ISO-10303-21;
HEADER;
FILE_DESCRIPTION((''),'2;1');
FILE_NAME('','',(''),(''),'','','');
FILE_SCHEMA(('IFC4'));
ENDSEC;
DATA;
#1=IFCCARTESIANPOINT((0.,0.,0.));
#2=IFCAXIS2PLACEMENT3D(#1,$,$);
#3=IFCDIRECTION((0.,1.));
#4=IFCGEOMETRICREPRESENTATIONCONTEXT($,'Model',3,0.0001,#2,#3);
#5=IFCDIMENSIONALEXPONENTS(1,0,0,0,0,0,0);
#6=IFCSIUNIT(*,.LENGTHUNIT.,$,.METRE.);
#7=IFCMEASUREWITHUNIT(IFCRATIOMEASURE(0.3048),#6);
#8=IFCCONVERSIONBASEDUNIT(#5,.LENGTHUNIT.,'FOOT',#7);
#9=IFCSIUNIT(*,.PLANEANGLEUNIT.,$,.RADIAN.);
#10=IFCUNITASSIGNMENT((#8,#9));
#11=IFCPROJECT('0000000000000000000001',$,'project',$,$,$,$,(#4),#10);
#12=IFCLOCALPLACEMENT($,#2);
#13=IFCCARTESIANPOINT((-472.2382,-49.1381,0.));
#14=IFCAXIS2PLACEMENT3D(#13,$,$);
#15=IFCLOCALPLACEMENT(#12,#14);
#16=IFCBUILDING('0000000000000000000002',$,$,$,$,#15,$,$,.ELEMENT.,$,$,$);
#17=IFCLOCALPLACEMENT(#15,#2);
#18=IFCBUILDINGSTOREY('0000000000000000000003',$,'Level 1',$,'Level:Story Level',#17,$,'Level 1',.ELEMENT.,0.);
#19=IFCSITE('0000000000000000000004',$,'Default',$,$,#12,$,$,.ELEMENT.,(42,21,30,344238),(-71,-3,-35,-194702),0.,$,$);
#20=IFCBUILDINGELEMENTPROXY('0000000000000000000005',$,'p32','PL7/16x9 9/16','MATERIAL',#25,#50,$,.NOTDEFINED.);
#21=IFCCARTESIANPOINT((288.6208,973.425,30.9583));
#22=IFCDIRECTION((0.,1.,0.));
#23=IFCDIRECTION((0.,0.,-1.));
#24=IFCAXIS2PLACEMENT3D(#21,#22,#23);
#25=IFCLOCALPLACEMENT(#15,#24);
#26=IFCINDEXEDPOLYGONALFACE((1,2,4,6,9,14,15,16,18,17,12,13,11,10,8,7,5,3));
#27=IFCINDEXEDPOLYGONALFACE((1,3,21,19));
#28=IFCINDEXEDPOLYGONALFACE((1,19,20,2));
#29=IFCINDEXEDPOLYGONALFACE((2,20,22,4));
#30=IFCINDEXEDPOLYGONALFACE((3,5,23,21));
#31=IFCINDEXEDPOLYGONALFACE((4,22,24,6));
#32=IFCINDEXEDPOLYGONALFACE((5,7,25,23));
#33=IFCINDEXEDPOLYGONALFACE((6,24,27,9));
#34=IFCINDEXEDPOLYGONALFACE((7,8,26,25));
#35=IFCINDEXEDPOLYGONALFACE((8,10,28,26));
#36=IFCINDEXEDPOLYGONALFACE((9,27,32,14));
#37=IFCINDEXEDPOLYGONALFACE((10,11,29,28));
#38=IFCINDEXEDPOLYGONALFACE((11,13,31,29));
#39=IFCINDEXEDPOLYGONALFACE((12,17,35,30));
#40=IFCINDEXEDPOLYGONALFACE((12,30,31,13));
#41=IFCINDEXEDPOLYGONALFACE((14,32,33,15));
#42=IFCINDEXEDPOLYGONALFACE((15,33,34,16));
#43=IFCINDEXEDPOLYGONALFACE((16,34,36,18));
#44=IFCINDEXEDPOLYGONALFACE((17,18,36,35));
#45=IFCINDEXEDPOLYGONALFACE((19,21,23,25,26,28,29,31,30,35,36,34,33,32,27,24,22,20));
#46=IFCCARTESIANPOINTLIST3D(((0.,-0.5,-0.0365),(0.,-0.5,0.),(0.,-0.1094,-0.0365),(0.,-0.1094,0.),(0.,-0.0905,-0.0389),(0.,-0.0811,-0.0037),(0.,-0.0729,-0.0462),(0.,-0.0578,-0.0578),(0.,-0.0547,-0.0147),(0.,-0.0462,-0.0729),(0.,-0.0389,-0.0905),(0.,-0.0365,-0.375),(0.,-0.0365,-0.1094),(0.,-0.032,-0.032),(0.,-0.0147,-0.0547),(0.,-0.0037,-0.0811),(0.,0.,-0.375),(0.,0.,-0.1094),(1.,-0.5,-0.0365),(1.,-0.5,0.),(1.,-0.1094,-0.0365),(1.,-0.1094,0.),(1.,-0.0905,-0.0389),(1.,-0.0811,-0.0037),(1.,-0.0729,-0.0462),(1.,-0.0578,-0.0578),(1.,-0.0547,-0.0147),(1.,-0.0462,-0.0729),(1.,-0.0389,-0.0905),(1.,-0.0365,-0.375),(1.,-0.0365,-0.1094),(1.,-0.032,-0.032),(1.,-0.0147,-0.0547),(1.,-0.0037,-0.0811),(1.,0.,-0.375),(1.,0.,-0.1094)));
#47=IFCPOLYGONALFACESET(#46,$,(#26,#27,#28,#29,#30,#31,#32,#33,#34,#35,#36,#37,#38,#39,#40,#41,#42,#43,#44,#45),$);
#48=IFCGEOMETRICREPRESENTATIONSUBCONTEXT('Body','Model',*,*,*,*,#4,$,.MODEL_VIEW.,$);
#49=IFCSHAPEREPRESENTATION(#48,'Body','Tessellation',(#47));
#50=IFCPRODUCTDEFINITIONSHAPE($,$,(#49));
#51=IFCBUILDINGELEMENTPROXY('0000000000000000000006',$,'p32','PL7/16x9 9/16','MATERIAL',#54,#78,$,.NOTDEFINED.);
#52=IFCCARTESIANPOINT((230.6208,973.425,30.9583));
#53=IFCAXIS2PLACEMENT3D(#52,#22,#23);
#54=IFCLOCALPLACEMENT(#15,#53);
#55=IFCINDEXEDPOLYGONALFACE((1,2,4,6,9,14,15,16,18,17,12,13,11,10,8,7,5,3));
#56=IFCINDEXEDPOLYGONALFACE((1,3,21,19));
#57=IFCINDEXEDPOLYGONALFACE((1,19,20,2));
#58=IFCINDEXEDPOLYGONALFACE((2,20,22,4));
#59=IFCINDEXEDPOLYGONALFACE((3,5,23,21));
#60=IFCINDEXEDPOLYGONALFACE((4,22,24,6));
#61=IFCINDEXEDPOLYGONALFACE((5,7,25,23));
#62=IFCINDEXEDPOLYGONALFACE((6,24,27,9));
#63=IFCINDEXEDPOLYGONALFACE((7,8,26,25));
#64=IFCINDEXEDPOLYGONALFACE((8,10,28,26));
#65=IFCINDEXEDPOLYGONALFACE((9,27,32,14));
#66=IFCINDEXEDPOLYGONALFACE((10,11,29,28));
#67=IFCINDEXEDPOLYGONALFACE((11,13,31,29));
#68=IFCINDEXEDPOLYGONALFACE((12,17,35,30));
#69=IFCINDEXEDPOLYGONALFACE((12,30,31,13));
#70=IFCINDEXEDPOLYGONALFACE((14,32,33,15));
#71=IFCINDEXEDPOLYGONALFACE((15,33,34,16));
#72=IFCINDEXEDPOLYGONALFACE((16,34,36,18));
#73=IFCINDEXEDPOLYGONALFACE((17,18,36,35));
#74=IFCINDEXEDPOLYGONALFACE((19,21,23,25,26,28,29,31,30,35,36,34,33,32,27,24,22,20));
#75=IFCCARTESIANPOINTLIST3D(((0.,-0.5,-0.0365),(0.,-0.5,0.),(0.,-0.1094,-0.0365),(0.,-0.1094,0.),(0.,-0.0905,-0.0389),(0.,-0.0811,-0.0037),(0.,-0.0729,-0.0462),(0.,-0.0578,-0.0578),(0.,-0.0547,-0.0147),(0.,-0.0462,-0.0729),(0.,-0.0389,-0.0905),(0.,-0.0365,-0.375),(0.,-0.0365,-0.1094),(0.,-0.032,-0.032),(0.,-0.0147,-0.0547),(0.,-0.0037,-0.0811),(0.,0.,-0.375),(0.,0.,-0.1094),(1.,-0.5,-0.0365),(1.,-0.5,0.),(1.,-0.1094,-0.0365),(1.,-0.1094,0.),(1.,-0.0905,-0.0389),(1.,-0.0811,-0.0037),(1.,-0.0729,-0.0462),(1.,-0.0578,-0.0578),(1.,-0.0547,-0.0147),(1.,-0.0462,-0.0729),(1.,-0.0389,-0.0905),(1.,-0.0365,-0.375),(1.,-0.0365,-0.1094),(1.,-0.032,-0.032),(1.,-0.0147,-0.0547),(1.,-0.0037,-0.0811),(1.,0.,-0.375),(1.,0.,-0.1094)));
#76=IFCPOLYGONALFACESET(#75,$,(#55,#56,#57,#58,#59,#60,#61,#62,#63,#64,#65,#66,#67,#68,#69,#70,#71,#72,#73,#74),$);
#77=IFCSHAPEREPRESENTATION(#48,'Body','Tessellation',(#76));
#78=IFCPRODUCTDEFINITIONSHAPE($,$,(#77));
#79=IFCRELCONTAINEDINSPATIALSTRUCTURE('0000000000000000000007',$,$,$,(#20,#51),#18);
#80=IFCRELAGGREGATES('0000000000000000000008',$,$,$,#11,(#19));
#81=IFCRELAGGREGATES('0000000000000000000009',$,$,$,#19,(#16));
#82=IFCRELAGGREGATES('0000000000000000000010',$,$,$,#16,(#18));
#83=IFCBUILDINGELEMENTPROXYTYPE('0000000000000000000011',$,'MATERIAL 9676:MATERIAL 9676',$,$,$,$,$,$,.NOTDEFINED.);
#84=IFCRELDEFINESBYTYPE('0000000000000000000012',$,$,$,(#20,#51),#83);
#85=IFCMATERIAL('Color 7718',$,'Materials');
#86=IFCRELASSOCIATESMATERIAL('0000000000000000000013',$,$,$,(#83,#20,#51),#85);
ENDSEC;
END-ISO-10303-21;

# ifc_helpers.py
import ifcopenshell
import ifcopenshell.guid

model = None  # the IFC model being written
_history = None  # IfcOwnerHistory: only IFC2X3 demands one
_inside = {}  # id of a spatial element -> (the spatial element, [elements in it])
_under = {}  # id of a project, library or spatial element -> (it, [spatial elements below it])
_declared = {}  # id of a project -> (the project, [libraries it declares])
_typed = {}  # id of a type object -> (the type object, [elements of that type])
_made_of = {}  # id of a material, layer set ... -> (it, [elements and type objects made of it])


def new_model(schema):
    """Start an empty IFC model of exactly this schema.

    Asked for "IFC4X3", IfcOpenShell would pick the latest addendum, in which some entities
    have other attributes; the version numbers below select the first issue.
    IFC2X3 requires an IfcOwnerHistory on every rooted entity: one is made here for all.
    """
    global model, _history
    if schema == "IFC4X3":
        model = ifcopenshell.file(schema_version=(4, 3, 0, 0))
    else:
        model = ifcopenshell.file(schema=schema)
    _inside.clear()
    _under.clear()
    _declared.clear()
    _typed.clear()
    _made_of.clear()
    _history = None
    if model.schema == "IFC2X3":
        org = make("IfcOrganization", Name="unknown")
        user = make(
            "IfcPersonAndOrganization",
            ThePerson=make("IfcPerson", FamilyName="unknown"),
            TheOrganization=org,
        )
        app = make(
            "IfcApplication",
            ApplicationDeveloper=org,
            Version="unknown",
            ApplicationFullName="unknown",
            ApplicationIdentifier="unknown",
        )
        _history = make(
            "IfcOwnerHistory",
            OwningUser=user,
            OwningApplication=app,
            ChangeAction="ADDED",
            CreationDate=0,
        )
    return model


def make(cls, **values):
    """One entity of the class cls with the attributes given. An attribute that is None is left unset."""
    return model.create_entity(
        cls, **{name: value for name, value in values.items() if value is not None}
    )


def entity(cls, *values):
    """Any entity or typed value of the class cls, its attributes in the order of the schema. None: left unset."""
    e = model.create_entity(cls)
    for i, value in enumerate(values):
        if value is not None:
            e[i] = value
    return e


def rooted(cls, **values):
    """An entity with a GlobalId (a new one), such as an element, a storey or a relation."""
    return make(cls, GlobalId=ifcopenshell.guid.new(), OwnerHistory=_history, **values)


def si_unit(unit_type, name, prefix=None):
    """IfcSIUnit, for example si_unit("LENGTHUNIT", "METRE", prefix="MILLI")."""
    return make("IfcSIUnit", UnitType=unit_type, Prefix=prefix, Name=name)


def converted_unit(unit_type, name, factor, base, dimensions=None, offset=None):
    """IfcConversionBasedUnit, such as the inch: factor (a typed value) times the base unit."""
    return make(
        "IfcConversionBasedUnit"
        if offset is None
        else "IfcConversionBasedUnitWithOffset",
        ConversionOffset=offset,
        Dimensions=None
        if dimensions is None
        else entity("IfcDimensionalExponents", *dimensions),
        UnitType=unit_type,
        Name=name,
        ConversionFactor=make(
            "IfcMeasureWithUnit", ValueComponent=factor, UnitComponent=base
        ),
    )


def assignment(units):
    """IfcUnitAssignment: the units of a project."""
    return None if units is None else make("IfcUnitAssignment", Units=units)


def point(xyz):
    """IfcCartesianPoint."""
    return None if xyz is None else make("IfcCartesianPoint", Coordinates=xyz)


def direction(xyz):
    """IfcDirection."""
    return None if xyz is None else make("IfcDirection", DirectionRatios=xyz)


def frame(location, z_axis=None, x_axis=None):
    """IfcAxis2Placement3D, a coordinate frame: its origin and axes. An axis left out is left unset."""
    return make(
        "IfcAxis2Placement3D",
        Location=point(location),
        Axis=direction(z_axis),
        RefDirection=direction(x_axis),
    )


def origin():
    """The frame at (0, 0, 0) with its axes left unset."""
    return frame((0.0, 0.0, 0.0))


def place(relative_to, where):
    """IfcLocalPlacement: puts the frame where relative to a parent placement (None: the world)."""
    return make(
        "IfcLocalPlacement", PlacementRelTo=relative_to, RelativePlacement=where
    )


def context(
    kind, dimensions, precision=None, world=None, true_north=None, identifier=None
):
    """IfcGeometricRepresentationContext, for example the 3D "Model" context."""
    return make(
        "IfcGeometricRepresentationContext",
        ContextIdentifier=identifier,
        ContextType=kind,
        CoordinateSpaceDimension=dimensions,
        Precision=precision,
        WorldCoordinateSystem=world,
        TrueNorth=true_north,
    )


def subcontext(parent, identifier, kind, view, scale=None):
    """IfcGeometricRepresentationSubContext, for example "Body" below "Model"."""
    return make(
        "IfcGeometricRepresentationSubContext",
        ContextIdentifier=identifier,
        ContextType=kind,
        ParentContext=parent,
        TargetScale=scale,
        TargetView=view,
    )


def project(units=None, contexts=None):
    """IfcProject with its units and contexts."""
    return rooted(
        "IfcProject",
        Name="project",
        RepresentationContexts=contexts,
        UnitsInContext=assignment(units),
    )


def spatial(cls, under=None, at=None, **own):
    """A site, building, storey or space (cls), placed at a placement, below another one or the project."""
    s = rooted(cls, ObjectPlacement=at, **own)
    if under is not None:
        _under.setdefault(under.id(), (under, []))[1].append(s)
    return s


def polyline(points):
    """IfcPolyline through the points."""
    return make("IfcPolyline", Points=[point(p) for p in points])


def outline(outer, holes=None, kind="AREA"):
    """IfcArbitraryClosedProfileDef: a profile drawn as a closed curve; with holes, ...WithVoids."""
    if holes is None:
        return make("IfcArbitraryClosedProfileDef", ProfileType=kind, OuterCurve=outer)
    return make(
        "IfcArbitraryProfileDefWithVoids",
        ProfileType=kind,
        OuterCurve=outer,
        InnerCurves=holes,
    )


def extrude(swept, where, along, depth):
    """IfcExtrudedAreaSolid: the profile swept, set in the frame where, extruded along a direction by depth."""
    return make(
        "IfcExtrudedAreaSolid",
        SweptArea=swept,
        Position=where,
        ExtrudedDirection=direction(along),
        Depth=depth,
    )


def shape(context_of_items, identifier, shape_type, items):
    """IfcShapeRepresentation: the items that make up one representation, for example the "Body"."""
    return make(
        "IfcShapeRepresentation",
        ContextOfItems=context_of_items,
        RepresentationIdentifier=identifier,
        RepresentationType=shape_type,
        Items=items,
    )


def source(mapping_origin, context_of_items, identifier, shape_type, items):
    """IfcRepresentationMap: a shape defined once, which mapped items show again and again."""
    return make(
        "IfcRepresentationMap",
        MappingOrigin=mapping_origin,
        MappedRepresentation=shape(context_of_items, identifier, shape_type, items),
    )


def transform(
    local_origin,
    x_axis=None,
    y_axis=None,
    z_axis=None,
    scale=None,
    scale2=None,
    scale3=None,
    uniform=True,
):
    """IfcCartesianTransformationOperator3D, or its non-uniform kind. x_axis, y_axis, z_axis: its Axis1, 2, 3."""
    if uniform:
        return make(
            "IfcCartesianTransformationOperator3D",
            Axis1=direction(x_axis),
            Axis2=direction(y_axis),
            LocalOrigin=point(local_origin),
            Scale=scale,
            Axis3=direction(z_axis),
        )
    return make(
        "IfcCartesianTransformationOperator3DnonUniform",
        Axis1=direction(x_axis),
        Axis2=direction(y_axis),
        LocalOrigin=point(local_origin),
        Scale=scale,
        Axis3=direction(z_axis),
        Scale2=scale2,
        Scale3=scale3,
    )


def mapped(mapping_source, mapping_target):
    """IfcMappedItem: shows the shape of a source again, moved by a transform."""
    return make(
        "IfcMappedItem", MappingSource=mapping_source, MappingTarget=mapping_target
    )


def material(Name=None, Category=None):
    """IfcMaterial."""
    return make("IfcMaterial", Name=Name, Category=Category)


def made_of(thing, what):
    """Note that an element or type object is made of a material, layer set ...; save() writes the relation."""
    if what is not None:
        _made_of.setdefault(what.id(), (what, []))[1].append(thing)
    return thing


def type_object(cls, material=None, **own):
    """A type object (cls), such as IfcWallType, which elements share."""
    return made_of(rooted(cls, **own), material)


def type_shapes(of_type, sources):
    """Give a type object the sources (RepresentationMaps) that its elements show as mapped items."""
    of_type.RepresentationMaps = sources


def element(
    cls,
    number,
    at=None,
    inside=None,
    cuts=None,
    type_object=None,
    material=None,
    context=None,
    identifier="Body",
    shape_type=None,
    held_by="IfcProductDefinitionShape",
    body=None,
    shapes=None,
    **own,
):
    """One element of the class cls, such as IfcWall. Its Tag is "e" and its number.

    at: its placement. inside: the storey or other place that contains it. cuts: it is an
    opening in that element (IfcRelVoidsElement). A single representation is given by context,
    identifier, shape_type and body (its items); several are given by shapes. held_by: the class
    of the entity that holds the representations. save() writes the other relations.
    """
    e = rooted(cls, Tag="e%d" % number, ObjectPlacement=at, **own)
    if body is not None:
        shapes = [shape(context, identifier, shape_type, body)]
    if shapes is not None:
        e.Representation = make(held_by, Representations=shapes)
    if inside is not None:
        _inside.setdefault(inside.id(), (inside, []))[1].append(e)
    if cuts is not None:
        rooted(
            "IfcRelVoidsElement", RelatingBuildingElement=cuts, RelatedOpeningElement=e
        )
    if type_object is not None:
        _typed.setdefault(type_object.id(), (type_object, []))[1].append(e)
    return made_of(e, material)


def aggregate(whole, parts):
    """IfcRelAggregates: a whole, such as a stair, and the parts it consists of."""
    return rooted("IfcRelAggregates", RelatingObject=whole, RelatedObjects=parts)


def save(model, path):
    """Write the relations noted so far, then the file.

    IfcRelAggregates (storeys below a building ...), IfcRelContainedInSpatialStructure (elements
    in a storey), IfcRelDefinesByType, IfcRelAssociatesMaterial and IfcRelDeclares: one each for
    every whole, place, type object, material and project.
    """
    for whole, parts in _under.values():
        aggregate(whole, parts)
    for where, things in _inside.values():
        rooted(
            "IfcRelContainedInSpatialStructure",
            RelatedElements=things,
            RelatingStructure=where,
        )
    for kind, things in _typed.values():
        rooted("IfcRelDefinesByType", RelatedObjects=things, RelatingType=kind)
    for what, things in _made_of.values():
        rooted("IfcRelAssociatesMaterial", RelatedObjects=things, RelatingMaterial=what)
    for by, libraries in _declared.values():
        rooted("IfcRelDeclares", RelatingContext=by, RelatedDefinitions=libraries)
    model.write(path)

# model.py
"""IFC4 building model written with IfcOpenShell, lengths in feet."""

from ifc_helpers import new_model, entity, si_unit, converted_unit, direction, frame, origin, place, context, subcontext, project, spatial, polyline, outline, extrude, source, transform, mapped, material, type_object, type_shapes, element, save


model = new_model("IFC4")

# Units and contexts
model_context = context("Model", 3, precision=0.0001, world=origin(), true_north=direction((0.0, 1.0)))
body_context = subcontext(model_context, "Body", "Model", "MODEL_VIEW")
ifc_project = project(units=[converted_unit("LENGTHUNIT", "FOOT", entity("IfcRatioMeasure", 0.3048), si_unit("LENGTHUNIT", "METRE"), dimensions=[1, 0, 0, 0, 0, 0, 0]), si_unit("PLANEANGLEUNIT", "RADIAN")], contexts=[model_context])

# Site, building, storey
site_placement = place(None, origin())
site = spatial("IfcSite", under=ifc_project, at=site_placement, Name="Default", CompositionType="ELEMENT", RefLatitude=(42, 21, 30, 344238), RefLongitude=(-71, -3, -35, -194702), RefElevation=0.0)
building_placement = place(site_placement, frame((-472.2382, -49.1381, 0.0)))
building = spatial("IfcBuilding", under=site, at=building_placement, CompositionType="ELEMENT")
storey_placement = place(building_placement, origin())
storey = spatial("IfcBuildingStorey", under=building, at=storey_placement, Name="Level 1", ObjectType="Level:Story Level", LongName="Level 1", CompositionType="ELEMENT", Elevation=0.0)

# Building element proxies
ifc_material_1 = material(Name="Color 7718", Category="Materials")
building_element_proxy_type_1 = type_object("IfcBuildingElementProxyType", Name="MATERIAL 9676:MATERIAL 9676", PredefinedType="NOTDEFINED", material=ifc_material_1)
shared_shape_1 = source(origin(), body_context, "Body", "SweptSolid", [
    extrude(outline(polyline([(0.0103, -0.0852), (0.4009, -0.0852), (0.4009, -0.0488), (0.0103, -0.0488), (-0.0086, -0.0463), (-0.0262, -0.039), (-0.0413, -0.0274), (-0.0529, -0.0123), (-0.0602, 0.0053), (-0.0627, 0.0241), (-0.0627, 0.2898), (-0.0991, 0.2898), (-0.0991, 0.0241), (-0.0954, -0.0042), (-0.0845, -0.0305), (-0.0671, -0.0532), (-0.0444, -0.0706), (-0.0181, -0.0815), (0.0103, -0.0852)])), frame((0.0, -0.0991, -0.0852), z_axis=(1.0, 0.0, 0.0), x_axis=(0.0, -1.0, 0.0)), (0.0, 0.0, 1.0), 1.0),
])
type_shapes(building_element_proxy_type_1, [shared_shape_1])
for number, where, z_axis, x_axis, name in (
    (1, (288.6208, 973.425, 30.9583), (0.0, 1.0, 0.0), (0.0, 0.0, -1.0), "p32"),
    (2, (230.6208, 973.425, 30.9583), (0.0, 1.0, 0.0), (0.0, 0.0, -1.0), "p32"),
):
    element("IfcBuildingElementProxy", number, at=place(building_placement, frame(where, z_axis=z_axis, x_axis=x_axis)), inside=storey, type_object=building_element_proxy_type_1, material=ifc_material_1, Name=name, Description="PL7/16x9 9/16", ObjectType="MATERIAL", PredefinedType="NOTDEFINED", context=body_context, shape_type="MappedRepresentation", body=[
        mapped(shared_shape_1, transform((0.0, 0.0, 0.0), scale=1.0)),
    ])

save(model, "model.ifc")
